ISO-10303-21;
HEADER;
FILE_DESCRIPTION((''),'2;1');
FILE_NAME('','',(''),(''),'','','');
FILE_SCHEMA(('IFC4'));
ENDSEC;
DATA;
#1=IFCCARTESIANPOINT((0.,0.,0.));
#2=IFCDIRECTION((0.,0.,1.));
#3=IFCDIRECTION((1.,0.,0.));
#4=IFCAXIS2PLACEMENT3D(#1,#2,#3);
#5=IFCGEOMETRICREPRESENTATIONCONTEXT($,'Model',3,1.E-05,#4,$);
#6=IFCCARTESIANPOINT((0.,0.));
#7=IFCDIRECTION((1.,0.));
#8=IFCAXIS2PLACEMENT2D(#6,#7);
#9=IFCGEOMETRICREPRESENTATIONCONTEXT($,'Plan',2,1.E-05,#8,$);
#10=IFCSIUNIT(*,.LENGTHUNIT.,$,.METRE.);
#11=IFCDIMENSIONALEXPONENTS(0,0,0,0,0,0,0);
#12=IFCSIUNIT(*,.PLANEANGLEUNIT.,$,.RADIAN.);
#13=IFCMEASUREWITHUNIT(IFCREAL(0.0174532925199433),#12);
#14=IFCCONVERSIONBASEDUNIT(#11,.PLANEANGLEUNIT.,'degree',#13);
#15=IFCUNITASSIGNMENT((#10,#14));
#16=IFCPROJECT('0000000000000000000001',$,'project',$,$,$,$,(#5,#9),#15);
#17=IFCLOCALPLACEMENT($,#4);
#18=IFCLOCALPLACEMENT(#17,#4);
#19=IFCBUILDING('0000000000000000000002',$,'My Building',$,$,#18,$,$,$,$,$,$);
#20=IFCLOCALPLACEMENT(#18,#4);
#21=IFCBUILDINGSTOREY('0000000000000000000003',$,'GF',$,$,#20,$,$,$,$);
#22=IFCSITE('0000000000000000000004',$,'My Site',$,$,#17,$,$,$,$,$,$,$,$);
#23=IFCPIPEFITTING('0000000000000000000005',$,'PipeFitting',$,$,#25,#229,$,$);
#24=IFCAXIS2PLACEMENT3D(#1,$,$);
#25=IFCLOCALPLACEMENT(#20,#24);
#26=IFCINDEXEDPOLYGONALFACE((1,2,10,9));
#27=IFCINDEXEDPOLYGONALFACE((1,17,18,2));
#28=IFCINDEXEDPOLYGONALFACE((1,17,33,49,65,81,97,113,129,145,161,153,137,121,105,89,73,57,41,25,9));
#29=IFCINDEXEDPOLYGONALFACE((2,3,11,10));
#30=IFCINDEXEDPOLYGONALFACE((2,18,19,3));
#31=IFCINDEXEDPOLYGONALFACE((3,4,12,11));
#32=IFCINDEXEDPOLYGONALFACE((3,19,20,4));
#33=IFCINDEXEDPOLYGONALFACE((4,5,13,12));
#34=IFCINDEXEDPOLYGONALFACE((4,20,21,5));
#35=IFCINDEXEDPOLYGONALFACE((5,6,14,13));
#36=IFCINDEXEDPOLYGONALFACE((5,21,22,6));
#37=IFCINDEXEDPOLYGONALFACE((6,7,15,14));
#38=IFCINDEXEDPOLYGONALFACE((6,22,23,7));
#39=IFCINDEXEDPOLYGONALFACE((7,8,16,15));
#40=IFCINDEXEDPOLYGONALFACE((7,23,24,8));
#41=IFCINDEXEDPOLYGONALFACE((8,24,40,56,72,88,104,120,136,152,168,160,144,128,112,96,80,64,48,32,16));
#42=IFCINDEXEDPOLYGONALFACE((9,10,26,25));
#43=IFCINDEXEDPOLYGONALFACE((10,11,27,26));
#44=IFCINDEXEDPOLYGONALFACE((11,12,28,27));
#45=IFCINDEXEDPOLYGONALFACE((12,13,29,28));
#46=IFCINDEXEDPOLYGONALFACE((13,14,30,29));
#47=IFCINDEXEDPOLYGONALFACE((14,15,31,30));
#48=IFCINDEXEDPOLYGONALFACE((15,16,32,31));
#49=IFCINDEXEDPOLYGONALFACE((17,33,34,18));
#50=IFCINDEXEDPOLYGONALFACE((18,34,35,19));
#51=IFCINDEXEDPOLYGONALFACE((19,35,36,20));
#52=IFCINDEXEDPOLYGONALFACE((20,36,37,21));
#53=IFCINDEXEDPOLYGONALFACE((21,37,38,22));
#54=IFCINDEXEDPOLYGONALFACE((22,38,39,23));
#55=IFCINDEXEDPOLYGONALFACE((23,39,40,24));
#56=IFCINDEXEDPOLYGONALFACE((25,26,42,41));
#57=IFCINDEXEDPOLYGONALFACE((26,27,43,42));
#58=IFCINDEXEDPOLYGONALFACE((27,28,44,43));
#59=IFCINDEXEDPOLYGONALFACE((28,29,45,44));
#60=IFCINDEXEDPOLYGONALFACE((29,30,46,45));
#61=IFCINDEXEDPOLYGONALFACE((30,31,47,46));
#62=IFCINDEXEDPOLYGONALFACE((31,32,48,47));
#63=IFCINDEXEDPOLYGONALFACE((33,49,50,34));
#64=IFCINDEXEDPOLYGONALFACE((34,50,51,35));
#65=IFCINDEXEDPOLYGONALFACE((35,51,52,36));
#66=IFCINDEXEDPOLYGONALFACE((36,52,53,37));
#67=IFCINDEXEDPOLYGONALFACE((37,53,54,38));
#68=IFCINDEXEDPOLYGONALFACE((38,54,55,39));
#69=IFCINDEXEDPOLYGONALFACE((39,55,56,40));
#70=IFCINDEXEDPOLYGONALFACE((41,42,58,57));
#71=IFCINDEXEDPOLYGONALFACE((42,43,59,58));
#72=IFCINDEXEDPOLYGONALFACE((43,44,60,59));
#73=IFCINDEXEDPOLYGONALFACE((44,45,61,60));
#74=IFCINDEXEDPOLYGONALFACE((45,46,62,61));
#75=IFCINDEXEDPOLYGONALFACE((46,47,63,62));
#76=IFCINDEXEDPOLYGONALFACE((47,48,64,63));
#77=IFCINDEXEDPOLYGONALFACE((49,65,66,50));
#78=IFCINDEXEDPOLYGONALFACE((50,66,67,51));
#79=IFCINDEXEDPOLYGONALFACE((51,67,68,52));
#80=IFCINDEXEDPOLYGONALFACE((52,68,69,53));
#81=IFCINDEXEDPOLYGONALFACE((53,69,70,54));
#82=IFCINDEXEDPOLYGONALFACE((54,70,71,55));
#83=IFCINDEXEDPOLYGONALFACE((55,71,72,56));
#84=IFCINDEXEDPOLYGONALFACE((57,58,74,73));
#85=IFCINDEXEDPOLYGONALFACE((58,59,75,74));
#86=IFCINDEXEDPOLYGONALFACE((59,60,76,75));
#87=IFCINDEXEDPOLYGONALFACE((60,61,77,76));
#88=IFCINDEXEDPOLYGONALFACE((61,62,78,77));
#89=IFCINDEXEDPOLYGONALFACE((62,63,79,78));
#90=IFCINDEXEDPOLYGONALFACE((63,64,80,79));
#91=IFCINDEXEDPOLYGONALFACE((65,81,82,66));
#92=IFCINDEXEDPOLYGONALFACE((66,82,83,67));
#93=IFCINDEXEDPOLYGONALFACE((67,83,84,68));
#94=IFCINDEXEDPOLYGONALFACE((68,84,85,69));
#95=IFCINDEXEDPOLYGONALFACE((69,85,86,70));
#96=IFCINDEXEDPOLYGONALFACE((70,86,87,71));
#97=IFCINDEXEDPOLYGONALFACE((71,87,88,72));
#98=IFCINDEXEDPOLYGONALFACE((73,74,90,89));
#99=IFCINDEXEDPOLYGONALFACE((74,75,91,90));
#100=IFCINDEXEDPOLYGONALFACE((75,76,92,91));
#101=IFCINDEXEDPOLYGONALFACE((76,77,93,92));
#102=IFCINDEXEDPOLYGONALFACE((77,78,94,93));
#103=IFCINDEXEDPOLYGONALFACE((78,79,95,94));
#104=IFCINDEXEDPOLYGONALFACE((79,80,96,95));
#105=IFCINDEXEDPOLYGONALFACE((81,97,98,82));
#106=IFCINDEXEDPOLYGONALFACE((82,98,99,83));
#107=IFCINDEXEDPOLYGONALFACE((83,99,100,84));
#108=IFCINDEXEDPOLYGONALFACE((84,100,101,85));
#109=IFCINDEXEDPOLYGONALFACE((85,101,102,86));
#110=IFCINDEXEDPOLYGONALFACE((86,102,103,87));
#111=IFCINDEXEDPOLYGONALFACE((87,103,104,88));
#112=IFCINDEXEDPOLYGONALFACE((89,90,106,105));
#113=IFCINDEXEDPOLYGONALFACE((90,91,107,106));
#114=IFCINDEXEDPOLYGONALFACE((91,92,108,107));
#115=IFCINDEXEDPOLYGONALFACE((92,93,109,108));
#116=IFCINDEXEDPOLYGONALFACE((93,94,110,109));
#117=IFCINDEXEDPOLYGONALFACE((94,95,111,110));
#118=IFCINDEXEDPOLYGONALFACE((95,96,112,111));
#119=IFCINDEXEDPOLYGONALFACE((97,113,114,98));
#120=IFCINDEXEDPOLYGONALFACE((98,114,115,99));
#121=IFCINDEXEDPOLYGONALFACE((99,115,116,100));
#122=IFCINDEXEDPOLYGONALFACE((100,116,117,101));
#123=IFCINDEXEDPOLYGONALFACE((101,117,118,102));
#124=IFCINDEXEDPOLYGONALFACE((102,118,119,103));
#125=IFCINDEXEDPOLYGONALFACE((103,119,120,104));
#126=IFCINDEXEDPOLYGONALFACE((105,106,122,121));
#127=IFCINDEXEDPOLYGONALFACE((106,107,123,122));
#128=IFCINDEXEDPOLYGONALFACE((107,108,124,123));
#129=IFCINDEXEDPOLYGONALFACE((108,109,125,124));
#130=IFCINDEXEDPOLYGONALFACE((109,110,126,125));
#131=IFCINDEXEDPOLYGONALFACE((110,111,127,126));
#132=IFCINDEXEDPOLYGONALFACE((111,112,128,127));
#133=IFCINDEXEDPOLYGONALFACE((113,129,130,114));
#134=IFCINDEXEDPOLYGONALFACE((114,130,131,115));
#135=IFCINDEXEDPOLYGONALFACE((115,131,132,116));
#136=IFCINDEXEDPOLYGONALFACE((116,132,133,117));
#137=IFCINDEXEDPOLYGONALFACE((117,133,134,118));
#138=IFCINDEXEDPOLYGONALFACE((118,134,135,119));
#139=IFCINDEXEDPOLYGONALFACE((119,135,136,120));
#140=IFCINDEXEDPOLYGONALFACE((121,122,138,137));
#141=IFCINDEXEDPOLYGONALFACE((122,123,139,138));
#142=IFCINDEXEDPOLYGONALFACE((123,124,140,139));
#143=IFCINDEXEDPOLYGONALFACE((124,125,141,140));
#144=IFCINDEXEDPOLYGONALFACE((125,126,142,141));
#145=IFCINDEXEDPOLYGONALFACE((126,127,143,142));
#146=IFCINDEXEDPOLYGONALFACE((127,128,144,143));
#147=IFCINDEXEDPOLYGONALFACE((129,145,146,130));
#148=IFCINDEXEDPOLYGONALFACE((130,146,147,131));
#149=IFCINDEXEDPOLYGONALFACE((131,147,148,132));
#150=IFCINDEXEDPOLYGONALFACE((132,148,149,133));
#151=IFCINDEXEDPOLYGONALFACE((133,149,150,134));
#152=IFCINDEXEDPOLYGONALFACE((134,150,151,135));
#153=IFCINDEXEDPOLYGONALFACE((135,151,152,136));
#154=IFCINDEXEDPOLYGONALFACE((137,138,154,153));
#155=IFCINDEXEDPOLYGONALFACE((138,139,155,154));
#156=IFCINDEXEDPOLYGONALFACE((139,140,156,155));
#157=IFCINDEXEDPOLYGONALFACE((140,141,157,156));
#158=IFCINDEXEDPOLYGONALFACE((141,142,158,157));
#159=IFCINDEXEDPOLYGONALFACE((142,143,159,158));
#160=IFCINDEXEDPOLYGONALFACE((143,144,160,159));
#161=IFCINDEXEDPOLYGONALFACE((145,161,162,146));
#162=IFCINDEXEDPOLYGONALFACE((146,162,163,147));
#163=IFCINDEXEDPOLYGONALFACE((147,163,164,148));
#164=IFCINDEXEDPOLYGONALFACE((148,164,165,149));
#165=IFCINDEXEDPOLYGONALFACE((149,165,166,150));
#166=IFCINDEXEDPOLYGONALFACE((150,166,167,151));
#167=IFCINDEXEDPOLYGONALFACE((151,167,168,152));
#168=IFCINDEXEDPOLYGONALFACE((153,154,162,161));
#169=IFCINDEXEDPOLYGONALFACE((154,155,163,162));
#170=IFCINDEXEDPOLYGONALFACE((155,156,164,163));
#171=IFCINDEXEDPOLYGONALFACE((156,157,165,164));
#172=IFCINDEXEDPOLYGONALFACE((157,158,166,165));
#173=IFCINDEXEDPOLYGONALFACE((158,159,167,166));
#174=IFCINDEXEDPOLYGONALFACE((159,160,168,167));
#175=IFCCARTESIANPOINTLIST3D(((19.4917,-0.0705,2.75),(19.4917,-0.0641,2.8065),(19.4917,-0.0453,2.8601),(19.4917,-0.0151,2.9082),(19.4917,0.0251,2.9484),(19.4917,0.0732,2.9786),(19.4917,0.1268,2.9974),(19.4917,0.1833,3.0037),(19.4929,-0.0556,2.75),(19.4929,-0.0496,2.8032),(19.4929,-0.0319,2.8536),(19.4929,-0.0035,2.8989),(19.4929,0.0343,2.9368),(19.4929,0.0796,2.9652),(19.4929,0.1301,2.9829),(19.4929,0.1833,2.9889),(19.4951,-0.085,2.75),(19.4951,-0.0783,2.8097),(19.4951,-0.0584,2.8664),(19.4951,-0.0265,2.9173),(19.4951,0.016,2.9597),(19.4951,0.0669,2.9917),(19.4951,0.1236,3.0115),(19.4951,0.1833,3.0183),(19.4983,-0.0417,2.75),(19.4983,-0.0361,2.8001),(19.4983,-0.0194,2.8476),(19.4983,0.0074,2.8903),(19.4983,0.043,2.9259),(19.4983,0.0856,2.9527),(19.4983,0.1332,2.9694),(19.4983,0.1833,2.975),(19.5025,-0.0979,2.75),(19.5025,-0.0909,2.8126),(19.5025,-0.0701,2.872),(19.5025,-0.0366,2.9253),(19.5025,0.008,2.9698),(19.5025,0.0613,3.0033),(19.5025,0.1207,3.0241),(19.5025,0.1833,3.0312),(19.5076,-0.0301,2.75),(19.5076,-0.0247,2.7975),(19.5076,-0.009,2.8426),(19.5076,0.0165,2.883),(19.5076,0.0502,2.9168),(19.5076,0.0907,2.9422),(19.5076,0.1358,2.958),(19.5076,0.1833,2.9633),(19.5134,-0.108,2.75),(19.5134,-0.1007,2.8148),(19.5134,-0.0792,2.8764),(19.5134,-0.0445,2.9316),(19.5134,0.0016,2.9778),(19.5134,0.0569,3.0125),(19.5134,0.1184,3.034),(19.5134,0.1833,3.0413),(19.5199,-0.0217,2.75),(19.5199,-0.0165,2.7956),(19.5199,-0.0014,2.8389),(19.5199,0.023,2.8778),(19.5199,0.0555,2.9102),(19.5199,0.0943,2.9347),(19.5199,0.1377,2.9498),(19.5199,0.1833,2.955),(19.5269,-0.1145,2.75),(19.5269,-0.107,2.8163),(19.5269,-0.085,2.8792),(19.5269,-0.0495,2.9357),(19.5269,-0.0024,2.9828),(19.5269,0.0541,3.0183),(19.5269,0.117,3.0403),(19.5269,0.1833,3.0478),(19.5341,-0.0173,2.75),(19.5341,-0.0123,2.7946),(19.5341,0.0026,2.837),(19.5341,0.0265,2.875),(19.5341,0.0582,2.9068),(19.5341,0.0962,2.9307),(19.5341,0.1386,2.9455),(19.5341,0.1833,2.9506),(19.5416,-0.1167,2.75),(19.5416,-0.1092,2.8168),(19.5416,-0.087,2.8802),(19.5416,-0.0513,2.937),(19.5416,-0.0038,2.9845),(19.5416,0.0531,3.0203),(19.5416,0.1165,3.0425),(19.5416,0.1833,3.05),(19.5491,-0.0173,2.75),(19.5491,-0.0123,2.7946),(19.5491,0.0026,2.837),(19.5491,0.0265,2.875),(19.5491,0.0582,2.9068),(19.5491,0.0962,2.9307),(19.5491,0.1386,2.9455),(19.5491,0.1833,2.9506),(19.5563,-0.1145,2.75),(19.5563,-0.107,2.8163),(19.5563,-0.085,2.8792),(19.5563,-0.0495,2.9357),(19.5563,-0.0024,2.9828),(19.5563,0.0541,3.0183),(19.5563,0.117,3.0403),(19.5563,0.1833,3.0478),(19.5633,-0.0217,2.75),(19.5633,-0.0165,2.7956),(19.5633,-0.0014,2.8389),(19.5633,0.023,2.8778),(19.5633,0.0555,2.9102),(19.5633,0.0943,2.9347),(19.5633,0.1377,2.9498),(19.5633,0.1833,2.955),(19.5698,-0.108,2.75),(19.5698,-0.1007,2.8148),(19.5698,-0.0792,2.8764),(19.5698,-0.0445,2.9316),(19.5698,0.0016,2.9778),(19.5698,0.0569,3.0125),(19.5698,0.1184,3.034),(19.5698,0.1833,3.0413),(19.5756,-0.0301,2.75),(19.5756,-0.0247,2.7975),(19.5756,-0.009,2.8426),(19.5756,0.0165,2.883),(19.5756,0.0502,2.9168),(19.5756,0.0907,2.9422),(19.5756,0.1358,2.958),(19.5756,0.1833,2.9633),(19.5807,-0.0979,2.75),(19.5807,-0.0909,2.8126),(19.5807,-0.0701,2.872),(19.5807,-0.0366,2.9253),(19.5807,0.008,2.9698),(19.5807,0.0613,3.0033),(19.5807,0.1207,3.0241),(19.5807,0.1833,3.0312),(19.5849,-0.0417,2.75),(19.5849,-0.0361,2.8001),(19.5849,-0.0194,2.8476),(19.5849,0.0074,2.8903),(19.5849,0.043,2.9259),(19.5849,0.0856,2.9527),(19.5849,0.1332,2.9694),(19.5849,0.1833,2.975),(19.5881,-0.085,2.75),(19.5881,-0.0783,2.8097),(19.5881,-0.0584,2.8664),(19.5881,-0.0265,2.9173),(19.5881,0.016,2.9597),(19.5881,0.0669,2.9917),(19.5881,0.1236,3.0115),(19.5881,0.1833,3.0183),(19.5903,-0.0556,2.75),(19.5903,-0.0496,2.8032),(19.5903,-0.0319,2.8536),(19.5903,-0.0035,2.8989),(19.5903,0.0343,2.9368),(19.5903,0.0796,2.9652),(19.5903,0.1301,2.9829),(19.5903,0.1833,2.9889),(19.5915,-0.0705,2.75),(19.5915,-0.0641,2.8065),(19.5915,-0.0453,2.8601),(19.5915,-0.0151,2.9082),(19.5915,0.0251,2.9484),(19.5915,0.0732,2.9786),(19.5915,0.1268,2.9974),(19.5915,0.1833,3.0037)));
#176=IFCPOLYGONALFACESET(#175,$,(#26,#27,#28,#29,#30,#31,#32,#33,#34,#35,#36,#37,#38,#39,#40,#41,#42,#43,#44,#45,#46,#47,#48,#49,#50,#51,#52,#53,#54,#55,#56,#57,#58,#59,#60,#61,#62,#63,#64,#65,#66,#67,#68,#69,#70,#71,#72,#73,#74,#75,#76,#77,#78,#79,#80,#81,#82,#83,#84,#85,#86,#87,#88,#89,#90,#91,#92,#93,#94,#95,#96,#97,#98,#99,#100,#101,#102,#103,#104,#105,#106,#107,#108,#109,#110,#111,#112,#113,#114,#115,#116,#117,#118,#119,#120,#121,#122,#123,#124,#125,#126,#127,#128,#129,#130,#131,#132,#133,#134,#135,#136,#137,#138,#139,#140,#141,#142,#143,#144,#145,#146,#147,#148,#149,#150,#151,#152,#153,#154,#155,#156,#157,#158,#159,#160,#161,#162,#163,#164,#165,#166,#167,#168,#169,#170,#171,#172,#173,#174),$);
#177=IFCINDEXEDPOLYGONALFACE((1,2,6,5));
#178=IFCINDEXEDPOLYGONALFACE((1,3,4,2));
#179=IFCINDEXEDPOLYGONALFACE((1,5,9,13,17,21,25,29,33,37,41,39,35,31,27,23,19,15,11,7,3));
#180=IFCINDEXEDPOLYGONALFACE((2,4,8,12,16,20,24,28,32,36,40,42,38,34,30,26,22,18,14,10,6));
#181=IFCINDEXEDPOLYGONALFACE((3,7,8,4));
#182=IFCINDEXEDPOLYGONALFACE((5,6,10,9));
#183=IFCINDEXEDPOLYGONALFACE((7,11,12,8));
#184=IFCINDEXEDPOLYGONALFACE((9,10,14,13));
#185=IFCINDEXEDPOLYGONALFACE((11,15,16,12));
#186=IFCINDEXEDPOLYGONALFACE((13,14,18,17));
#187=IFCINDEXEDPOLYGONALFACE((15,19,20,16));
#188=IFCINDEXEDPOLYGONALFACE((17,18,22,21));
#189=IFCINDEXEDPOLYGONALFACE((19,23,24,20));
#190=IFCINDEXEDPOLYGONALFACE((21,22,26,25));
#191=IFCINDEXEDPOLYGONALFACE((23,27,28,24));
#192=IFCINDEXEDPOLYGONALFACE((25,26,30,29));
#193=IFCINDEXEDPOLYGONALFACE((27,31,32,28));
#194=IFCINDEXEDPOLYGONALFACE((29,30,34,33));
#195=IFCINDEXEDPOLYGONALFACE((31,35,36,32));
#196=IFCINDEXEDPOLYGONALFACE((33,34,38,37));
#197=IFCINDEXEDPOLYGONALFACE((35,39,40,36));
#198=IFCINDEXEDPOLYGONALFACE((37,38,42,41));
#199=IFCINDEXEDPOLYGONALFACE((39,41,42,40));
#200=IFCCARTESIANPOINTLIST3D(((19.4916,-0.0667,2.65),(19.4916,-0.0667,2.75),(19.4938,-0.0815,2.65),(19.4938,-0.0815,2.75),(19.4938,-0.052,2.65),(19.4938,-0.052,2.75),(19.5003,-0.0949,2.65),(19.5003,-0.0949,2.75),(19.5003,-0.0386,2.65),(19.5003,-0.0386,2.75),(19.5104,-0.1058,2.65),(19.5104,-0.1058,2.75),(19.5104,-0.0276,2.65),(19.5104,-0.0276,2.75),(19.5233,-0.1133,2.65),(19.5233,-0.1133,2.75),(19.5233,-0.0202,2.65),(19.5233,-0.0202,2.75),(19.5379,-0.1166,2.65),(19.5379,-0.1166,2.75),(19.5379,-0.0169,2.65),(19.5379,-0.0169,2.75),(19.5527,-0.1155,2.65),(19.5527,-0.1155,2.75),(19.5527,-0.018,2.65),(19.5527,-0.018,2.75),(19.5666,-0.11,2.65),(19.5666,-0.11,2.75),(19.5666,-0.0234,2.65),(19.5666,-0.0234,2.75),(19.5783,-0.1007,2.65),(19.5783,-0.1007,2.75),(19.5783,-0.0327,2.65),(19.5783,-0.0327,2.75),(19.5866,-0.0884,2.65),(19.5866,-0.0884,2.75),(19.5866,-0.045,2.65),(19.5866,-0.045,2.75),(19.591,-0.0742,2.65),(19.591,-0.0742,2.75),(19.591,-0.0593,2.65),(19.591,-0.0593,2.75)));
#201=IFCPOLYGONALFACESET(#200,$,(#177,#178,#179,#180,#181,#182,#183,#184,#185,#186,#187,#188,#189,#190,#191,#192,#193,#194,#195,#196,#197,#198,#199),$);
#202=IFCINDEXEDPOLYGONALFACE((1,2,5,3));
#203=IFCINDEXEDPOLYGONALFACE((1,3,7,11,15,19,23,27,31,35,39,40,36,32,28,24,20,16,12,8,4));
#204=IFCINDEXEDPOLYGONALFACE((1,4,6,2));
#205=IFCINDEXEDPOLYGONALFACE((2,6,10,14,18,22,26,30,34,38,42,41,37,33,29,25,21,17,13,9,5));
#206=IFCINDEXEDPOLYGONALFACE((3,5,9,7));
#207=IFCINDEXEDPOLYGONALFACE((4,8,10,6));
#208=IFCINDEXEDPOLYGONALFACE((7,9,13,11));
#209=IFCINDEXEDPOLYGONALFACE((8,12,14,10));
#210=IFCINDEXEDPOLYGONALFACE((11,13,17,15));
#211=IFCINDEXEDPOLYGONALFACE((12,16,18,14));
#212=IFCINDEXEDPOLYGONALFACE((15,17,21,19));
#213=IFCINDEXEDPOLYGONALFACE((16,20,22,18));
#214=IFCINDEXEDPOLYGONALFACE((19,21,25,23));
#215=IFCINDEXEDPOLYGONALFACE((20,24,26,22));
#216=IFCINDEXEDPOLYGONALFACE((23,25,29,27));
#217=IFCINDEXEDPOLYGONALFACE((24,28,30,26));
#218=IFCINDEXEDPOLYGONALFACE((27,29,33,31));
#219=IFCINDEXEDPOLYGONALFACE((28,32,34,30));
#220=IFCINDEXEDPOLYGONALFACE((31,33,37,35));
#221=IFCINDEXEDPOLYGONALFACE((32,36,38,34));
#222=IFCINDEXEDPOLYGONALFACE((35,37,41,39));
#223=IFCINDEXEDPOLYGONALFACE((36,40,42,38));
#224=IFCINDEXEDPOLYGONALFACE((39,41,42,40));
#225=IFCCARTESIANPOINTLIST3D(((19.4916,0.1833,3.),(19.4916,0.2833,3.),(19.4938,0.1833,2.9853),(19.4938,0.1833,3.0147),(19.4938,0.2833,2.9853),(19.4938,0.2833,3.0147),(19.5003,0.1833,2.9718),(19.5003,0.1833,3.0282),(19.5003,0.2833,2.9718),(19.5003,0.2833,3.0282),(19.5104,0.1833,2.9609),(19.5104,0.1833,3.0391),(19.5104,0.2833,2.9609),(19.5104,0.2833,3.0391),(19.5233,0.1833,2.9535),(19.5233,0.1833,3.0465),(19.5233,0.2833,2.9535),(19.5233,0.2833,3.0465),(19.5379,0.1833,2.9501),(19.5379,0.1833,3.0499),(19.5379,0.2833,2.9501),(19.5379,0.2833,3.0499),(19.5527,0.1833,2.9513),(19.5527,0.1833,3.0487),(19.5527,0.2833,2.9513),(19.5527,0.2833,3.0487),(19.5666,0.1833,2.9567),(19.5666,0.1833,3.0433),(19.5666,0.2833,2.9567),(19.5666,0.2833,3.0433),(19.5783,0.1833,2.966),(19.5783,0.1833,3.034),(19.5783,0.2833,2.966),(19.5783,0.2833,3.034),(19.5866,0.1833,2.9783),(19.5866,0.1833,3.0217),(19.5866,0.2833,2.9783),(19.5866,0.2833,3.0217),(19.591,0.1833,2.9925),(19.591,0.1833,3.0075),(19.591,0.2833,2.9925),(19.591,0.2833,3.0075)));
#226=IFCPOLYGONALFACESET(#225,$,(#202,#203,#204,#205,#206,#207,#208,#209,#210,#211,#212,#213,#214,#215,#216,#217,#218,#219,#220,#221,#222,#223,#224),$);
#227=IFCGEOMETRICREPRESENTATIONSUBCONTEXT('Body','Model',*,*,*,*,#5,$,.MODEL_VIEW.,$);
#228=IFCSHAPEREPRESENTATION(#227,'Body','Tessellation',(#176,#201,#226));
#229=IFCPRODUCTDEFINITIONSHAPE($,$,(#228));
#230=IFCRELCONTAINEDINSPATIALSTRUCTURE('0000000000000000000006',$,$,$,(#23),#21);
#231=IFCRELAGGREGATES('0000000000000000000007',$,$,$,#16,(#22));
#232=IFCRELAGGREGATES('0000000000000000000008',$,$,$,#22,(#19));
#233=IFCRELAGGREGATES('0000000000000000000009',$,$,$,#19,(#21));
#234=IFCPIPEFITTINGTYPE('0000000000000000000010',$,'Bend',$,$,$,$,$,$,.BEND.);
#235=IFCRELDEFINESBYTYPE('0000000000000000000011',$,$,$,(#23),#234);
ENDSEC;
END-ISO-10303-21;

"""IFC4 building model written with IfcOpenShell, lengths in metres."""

from ifc_helpers import new_model, entity, si_unit, converted_unit, frame, origin_with_axes, origin_2d_with_axis, place, context, subcontext, project, spatial, circle, extrude, source, transform, mapped, type_object, type_shapes, element, save


model = new_model("IFC4")

# Units and contexts
model_context = context("Model", 3, precision=1e-05, world=origin_with_axes())
plan_context = context("Plan", 2, precision=1e-05, world=origin_2d_with_axis())
body_context_1 = subcontext(model_context, "Body", "Model", "MODEL_VIEW")
ifc_project = project(units=[si_unit("LENGTHUNIT", "METRE"), converted_unit("PLANEANGLEUNIT", "degree", entity("IfcReal", 0.0174532925199433), si_unit("PLANEANGLEUNIT", "RADIAN"), dimensions=[0, 0, 0, 0, 0, 0, 0])], contexts=[model_context, plan_context])

# Site, building, storey
site_placement = place(None, origin_with_axes())
site = spatial("IfcSite", under=ifc_project, at=site_placement, Name="My Site")
building_placement = place(site_placement, origin_with_axes())
building = spatial("IfcBuilding", under=site, at=building_placement, Name="My Building")
storey_placement = place(building_placement, origin_with_axes())
storey = spatial("IfcBuildingStorey", under=building, at=storey_placement, Name="GF")

# Pipe fitting
pipe_fitting_type = type_object("IfcPipeFittingType", Name="Bend", PredefinedType="BEND")
shared_shape_1 = source(origin_with_axes(), body_context_1, "Body", "SolidModel", [
    entity("IfcSweptDiskSolid", entity("IfcIndexedPolyCurve", entity("IfcCartesianPointList3D", [[0.0, 0.0, -0.1], [0.0, 0.0732, -0.2768], [0.0, 0.25, -0.35]]), [entity("IfcArcIndex", [1, 2, 3])]), 0.05),
    extrude(circle(Radius=0.05), origin_with_axes(), (0.0, 0.0, -1.0), 0.1),
    extrude(circle(Radius=0.05), frame((0.0, 0.25, -0.35), z_axis=(0.0, 1.0, 0.0), x_axis=(1.0, 0.0, 0.0)), (0.0, 0.0, 1.0), 0.1),
])
type_shapes(pipe_fitting_type, [shared_shape_1])
for number, where, z_axis, x_axis, name in (
    (1, (19.5416, -0.0667, 2.65), (0.0, 0.0, -1.0), (-1.0, 0.0, 0.0), "PipeFitting"),
):
    element("IfcPipeFitting", number, at=place(storey_placement, frame(where, z_axis=z_axis, x_axis=x_axis)), inside=storey, type_object=pipe_fitting_type, Name=name, context=body_context_1, shape_type="MappedRepresentation", body=[
        mapped(shared_shape_1, transform((0.0, 0.0, 0.0), x_axis=(1.0, 0.0, 0.0), y_axis=(0.0, 1.0, 0.0), z_axis=(0.0, 0.0, 1.0), scale=1.0)),
    ])

save(model, "model.ifc")
